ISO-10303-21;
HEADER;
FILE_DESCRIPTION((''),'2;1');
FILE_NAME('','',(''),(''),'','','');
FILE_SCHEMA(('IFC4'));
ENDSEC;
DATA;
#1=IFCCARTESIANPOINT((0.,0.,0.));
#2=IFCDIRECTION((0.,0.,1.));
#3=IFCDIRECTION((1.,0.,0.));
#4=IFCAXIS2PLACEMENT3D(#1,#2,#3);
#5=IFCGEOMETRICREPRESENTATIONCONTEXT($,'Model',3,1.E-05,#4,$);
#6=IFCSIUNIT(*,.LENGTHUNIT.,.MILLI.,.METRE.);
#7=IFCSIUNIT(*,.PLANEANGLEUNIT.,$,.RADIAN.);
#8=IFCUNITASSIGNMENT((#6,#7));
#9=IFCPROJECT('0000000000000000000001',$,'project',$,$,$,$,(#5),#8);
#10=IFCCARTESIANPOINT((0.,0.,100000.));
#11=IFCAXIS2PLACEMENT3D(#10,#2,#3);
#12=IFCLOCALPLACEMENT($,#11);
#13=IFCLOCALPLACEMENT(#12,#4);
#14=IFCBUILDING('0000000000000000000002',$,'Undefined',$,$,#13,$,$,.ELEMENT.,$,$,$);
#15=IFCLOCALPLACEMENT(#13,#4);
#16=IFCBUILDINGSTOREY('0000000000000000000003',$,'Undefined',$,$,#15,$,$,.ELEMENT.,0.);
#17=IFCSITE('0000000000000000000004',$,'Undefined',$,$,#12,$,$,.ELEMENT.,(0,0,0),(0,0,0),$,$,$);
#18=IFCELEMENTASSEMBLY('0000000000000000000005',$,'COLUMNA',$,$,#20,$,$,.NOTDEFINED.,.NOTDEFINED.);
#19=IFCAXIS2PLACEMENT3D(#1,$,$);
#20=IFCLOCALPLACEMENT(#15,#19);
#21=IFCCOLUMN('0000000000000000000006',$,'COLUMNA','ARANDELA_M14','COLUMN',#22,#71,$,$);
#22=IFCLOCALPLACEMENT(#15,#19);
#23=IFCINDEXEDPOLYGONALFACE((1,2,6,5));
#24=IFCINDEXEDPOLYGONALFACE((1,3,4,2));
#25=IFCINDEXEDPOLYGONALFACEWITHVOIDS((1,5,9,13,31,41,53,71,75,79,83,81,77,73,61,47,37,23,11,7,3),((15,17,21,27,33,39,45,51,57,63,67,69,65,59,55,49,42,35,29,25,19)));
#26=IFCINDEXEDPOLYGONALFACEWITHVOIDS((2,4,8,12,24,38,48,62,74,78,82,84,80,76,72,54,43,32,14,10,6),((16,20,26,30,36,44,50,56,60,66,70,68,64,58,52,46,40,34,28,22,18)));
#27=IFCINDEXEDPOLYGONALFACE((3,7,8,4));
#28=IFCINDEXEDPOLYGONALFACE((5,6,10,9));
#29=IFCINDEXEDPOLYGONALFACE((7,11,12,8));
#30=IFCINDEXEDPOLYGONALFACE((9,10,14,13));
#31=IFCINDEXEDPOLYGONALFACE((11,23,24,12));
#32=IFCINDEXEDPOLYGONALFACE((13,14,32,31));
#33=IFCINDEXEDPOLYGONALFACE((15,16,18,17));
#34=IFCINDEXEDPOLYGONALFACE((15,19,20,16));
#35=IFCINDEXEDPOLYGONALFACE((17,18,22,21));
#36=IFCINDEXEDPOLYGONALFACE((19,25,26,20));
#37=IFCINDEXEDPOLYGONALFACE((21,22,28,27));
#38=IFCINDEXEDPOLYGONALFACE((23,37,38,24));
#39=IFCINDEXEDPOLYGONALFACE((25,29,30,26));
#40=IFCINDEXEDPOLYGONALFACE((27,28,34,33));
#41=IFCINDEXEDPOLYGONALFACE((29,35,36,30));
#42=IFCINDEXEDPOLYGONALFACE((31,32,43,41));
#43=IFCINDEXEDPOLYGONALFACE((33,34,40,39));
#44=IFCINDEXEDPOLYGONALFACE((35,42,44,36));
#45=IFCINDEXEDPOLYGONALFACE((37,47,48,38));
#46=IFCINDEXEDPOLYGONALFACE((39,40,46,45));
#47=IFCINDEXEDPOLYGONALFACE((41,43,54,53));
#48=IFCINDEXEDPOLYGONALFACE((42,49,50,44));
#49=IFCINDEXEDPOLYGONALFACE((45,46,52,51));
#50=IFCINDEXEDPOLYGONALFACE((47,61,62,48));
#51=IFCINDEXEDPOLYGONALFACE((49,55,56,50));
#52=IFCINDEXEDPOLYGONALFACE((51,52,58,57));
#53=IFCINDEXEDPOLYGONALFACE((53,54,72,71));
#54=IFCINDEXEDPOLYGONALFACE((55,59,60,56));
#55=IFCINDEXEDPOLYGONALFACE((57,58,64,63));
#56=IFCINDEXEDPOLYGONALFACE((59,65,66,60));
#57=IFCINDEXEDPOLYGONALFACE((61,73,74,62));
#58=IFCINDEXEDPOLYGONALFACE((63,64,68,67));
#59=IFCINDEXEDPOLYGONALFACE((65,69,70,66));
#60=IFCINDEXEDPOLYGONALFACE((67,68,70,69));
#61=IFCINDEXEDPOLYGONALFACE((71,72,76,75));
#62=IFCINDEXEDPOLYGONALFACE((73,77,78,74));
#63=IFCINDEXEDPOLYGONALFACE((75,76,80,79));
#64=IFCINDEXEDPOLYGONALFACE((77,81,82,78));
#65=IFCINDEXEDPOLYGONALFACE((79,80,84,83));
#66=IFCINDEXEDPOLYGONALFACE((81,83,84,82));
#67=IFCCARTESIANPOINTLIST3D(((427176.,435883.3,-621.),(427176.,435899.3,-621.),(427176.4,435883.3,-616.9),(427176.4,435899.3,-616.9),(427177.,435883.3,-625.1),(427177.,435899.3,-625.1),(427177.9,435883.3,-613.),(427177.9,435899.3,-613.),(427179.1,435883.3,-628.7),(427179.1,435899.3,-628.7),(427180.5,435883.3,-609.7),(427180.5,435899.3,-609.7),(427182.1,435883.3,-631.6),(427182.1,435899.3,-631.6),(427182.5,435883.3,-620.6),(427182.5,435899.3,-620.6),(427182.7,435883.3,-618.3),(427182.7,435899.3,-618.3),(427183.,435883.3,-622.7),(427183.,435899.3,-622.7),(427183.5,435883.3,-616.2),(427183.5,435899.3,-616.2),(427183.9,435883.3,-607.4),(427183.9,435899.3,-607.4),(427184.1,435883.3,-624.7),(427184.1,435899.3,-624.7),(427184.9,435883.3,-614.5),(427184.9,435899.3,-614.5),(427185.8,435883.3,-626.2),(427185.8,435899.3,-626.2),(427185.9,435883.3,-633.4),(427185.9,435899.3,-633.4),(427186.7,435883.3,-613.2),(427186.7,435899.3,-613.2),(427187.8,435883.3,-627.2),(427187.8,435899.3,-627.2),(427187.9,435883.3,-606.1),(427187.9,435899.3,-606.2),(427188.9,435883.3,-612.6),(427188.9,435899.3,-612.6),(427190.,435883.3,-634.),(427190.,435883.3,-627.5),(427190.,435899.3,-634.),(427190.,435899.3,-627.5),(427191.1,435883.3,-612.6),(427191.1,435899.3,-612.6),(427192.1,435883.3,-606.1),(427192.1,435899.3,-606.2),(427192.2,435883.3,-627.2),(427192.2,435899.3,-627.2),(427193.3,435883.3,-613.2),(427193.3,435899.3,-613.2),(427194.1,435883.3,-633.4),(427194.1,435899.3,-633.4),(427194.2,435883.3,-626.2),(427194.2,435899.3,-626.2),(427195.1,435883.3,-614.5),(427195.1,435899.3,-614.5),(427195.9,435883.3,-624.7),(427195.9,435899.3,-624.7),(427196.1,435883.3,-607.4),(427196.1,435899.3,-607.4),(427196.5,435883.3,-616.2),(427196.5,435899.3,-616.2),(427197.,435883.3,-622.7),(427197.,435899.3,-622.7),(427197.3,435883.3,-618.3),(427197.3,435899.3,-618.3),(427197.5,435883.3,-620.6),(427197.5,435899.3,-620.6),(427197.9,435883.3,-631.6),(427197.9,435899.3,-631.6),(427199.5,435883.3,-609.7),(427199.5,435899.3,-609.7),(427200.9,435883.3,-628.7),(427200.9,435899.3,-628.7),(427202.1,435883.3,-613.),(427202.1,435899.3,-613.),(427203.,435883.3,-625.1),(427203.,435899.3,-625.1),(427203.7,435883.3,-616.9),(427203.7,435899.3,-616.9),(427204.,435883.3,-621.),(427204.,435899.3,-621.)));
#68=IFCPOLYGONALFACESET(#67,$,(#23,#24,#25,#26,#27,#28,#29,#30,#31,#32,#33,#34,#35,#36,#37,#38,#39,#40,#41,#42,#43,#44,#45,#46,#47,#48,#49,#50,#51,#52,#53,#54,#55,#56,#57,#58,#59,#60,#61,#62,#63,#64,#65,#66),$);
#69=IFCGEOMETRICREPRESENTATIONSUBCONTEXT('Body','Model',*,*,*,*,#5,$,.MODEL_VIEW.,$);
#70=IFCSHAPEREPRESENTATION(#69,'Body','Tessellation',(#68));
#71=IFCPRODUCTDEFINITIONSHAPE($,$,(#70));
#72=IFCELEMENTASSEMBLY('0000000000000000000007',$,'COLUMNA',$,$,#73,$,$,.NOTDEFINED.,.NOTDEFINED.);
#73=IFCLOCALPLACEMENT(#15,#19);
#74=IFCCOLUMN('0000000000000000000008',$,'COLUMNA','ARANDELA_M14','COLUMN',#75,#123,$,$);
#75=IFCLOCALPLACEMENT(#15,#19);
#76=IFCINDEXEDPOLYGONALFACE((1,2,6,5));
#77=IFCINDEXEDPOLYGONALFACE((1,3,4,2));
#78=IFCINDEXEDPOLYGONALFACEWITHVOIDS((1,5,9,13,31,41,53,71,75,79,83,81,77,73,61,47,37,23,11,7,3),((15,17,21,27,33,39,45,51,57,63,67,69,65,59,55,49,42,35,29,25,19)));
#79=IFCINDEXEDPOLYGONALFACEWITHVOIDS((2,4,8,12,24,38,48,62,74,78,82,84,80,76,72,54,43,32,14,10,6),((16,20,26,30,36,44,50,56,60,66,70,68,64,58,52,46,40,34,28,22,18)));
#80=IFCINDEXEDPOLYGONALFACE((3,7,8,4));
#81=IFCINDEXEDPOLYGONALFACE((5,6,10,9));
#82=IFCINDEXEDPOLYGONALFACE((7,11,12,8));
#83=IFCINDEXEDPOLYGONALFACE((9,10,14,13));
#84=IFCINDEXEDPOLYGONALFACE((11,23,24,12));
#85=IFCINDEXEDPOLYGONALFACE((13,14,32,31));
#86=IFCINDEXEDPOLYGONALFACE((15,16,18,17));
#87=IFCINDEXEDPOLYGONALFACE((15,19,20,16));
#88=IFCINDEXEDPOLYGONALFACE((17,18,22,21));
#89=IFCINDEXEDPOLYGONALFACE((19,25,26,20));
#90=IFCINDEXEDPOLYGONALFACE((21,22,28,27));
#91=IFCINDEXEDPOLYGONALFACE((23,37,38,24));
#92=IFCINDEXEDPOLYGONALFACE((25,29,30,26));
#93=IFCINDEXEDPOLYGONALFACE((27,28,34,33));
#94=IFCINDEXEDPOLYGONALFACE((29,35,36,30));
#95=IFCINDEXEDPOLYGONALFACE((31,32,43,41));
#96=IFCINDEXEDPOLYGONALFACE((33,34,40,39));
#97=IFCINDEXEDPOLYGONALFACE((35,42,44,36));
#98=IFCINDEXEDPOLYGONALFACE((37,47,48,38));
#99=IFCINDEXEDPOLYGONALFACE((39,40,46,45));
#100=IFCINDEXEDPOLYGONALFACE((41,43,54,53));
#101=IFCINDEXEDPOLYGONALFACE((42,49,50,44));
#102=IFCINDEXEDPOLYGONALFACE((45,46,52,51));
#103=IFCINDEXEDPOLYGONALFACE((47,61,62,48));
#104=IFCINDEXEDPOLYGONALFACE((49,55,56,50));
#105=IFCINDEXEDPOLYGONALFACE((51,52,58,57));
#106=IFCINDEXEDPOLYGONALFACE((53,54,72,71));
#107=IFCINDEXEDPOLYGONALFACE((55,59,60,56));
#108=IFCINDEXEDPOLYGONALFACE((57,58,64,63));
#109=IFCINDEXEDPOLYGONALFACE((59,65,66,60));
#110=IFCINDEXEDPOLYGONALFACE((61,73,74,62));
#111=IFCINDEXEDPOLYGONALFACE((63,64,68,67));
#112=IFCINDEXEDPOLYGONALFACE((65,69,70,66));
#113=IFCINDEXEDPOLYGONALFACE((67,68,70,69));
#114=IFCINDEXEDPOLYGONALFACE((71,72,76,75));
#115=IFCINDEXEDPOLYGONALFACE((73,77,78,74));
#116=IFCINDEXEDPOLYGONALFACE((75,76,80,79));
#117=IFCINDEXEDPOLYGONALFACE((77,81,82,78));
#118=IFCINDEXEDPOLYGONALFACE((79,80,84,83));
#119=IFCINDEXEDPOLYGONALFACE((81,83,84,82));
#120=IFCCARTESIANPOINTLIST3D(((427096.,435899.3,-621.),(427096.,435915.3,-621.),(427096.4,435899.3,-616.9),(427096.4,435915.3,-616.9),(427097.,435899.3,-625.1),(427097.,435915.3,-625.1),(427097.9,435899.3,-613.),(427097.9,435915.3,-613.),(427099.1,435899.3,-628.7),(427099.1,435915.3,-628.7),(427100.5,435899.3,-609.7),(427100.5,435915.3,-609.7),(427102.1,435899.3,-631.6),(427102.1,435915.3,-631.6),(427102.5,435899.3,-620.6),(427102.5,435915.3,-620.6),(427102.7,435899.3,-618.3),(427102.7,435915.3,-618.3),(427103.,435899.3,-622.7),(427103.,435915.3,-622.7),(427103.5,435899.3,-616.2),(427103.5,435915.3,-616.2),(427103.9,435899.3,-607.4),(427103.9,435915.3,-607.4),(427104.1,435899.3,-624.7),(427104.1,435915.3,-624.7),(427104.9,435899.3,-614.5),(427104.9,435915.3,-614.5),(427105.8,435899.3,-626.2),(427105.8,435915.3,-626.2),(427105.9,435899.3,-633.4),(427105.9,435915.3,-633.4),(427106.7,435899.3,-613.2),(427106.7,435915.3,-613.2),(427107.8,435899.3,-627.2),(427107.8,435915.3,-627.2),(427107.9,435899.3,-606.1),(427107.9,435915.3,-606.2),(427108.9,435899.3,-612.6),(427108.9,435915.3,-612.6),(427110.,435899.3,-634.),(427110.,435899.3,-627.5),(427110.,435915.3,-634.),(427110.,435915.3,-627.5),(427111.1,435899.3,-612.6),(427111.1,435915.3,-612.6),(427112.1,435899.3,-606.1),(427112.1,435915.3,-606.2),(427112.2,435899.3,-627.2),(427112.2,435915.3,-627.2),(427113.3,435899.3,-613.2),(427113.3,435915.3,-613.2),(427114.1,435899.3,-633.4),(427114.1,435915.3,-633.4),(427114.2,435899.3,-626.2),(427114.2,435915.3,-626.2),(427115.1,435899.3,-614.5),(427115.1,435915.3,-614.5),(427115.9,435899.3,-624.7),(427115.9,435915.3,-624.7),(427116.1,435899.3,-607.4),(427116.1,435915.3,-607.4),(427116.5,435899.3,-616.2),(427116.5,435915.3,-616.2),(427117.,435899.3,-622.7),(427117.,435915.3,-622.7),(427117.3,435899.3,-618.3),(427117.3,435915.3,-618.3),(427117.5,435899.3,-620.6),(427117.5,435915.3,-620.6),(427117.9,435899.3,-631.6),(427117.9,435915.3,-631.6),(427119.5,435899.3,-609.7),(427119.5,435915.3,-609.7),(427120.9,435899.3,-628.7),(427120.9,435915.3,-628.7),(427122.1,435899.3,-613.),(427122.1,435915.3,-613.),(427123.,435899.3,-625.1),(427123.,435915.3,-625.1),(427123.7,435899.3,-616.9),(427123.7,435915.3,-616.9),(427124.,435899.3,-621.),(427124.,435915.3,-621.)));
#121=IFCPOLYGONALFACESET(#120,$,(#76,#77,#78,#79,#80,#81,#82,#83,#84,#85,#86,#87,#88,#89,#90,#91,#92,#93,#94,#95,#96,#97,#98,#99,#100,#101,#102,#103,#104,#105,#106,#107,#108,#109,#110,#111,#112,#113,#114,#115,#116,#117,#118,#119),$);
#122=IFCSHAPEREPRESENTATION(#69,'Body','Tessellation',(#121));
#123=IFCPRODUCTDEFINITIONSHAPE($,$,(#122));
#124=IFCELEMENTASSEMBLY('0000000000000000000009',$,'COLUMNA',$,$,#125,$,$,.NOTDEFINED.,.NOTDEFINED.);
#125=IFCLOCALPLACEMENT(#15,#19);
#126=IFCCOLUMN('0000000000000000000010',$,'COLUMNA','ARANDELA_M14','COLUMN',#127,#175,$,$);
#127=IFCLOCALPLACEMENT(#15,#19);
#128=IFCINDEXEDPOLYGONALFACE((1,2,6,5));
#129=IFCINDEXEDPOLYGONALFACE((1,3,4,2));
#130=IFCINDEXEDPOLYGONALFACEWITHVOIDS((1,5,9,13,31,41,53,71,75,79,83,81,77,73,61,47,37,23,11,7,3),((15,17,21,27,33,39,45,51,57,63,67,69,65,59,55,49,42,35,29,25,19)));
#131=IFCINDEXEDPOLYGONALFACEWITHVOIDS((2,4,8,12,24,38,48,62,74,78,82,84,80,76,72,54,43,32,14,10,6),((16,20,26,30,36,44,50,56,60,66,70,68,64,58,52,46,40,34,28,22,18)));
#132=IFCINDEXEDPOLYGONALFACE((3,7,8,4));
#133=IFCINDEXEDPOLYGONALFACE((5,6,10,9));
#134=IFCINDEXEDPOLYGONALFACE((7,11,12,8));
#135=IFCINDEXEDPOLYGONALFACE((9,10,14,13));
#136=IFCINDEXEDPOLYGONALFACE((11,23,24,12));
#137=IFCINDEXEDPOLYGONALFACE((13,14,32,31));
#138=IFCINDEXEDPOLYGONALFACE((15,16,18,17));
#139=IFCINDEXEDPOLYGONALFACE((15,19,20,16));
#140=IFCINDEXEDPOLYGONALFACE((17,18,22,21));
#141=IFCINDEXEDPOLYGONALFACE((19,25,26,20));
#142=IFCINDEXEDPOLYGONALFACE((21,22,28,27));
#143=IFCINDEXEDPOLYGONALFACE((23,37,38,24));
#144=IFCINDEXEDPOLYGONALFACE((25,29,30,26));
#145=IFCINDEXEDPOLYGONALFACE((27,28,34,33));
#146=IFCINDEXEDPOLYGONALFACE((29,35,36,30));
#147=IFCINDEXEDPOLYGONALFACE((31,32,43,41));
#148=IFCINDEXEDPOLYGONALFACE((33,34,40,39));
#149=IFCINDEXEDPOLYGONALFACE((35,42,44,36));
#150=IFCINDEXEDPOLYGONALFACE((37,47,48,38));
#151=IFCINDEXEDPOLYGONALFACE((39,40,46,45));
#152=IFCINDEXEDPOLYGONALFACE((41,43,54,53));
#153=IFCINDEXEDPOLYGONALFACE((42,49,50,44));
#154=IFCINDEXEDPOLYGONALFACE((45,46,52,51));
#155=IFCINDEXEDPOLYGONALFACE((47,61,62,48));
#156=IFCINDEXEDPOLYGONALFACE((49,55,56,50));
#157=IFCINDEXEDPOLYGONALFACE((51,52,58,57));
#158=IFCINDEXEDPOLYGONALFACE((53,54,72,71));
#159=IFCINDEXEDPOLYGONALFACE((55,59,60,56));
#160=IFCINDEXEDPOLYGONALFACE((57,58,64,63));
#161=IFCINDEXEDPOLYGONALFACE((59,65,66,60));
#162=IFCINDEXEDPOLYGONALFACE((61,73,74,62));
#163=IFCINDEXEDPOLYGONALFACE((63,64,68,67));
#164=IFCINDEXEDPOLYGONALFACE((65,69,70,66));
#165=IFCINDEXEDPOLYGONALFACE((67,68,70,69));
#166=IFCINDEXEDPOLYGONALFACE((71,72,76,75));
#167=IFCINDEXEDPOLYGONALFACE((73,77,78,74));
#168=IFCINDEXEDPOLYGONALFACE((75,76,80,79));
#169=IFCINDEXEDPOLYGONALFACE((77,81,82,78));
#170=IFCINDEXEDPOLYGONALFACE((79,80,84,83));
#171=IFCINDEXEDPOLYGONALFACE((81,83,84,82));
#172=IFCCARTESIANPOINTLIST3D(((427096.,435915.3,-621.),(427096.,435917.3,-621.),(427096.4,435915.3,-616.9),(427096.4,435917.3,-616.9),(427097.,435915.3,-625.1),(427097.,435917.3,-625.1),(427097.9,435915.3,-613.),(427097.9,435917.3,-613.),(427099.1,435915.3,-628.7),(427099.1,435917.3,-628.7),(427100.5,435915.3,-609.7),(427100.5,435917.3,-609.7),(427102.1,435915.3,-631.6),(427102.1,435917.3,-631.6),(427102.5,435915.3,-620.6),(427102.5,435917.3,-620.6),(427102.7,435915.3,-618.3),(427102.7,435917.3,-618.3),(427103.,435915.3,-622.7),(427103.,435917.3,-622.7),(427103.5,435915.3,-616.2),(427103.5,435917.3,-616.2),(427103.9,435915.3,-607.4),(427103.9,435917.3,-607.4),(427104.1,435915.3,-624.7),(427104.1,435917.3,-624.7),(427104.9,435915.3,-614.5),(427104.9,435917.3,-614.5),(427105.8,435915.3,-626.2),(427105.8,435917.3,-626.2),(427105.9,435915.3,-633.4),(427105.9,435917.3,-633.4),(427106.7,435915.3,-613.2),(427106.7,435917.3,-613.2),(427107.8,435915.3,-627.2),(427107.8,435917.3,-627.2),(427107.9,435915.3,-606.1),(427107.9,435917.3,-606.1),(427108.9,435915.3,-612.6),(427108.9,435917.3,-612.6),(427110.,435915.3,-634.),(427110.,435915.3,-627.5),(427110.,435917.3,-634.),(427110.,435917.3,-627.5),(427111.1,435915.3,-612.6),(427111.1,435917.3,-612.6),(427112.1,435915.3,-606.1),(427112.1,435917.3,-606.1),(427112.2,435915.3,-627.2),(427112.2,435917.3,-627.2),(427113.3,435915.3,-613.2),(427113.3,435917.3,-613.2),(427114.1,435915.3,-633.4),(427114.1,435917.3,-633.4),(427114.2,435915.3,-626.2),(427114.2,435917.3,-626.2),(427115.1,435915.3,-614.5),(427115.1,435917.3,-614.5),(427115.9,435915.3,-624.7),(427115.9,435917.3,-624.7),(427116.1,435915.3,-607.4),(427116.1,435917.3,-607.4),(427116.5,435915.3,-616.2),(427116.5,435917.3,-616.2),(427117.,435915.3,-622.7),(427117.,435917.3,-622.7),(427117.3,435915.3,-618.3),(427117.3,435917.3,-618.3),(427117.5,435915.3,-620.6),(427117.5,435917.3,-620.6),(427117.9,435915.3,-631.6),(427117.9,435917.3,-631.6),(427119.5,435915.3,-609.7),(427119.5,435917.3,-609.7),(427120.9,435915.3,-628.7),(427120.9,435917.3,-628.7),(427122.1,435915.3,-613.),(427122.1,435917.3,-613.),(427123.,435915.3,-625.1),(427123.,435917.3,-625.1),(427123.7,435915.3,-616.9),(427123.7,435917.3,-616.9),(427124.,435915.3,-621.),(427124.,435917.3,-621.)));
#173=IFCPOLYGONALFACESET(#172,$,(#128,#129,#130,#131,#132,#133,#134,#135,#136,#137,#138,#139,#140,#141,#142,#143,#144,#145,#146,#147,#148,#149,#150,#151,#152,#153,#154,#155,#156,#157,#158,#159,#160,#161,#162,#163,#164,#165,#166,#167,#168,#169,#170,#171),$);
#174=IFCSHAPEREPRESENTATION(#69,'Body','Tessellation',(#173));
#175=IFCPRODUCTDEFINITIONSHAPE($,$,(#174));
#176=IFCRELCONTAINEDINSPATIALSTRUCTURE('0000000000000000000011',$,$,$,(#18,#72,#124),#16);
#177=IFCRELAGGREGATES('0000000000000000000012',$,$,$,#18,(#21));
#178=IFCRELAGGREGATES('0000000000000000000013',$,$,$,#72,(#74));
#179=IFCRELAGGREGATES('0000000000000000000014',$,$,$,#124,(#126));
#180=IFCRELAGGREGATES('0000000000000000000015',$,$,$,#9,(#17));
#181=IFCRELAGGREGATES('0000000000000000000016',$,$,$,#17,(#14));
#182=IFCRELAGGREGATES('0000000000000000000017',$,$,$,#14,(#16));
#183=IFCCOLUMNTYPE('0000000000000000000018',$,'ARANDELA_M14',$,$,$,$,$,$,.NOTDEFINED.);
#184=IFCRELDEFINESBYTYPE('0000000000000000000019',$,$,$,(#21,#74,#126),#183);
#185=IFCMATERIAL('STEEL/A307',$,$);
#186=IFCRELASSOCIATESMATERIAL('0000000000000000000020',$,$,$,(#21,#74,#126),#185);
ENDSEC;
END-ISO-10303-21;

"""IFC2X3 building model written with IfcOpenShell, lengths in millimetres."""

from ifc_helpers import new_model, si_unit, frame, origin_with_axes, origin_2d_with_axis, place, context, subcontext, project, spatial, hollow_circle, extrude, material, type_object, element, aggregate, save


model = new_model("IFC2X3")

# Units and contexts
model_context = context("Model", 3, precision=1e-05, world=origin_with_axes())
body_context = subcontext(model_context, "Body", "Model", "MODEL_VIEW")
ifc_project = project(units=[si_unit("LENGTHUNIT", "METRE", prefix="MILLI"), si_unit("PLANEANGLEUNIT", "RADIAN")], contexts=[model_context])

# Site, building, storey
site_placement = place(None, frame((0.0, 0.0, 100000.0), z_axis=(0.0, 0.0, 1.0), x_axis=(1.0, 0.0, 0.0)))
site = spatial("IfcSite", under=ifc_project, at=site_placement, Name="Undefined", CompositionType="ELEMENT", RefLatitude=(0, 0, 0), RefLongitude=(0, 0, 0))
building_placement = place(site_placement, origin_with_axes())
building = spatial("IfcBuilding", under=site, at=building_placement, Name="Undefined", CompositionType="ELEMENT")
storey_placement = place(building_placement, origin_with_axes())
storey = spatial("IfcBuildingStorey", under=building, at=storey_placement, Name="Undefined", CompositionType="ELEMENT", Elevation=0.0)

# Element assemblies, columns
ifc_material_1 = material(Name="STEEL/A307")
column_type = type_object("IfcColumnType", Name="ARANDELA_M14", PredefinedType="NOTDEFINED")
assembly_1_placement = place(storey_placement, origin_with_axes())
assembly_1 = element("IfcElementAssembly", 1, at=assembly_1_placement, inside=storey, Name="COLUMNA", AssemblyPlace="NOTDEFINED", PredefinedType="NOTDEFINED")
column_1_placement = place(assembly_1_placement, frame((427190.0, 435899.3, -620.0), z_axis=(0.0, -1.0, 0.000285), x_axis=(-1.0, 0.0, 0.0)))
column_1 = element("IfcColumn", 2, at=column_1_placement, type_object=column_type, material=ifc_material_1, Name="COLUMNA", Description="ARANDELA_M14", ObjectType="COLUMN", context=body_context, shape_type="SweptSolid", body=[
    extrude(hollow_circle(Radius=14.0, WallThickness=6.5, at=origin_2d_with_axis()), frame((0.0, 0.0, 16.0), z_axis=(0.0, 0.0, -1.0), x_axis=(0.0, 1.0, 0.0)), (0.0, 0.0, 1.0), 16.0),
])
aggregate(assembly_1, [column_1])
assembly_2_placement = place(storey_placement, origin_with_axes())
assembly_2 = element("IfcElementAssembly", 3, at=assembly_2_placement, inside=storey, Name="COLUMNA", AssemblyPlace="NOTDEFINED", PredefinedType="NOTDEFINED")
column_2_placement = place(assembly_2_placement, frame((427110.0, 435915.3, -620.0), z_axis=(0.0, -1.0, 0.000285), x_axis=(-1.0, 0.0, 0.0)))
column_2 = element("IfcColumn", 4, at=column_2_placement, type_object=column_type, material=ifc_material_1, Name="COLUMNA", Description="ARANDELA_M14", ObjectType="COLUMN", context=body_context, shape_type="SweptSolid", body=[
    extrude(hollow_circle(Radius=14.0, WallThickness=6.5, at=origin_2d_with_axis()), frame((0.0, 0.0, 16.0), z_axis=(0.0, 0.0, -1.0), x_axis=(0.0, 1.0, 0.0)), (0.0, 0.0, 1.0), 16.0),
])
aggregate(assembly_2, [column_2])
assembly_3_placement = place(storey_placement, origin_with_axes())
assembly_3 = element("IfcElementAssembly", 5, at=assembly_3_placement, inside=storey, Name="COLUMNA", AssemblyPlace="NOTDEFINED", PredefinedType="NOTDEFINED")
column_3_placement = place(assembly_3_placement, frame((427110.0, 435917.3, -620.0), z_axis=(0.0, -1.0, 0.000285), x_axis=(-1.0, 0.0, 0.0)))
column_3 = element("IfcColumn", 6, at=column_3_placement, type_object=column_type, material=ifc_material_1, Name="COLUMNA", Description="ARANDELA_M14", ObjectType="COLUMN", context=body_context, shape_type="SweptSolid", body=[
    extrude(hollow_circle(Radius=14.0, WallThickness=6.5, at=origin_2d_with_axis()), frame((0.0, 0.0, 2.0), z_axis=(0.0, 0.0, -1.0), x_axis=(0.0, 1.0, 0.0)), (0.0, 0.0, 1.0), 2.0),
])
aggregate(assembly_3, [column_3])

save(model, "model.ifc")
